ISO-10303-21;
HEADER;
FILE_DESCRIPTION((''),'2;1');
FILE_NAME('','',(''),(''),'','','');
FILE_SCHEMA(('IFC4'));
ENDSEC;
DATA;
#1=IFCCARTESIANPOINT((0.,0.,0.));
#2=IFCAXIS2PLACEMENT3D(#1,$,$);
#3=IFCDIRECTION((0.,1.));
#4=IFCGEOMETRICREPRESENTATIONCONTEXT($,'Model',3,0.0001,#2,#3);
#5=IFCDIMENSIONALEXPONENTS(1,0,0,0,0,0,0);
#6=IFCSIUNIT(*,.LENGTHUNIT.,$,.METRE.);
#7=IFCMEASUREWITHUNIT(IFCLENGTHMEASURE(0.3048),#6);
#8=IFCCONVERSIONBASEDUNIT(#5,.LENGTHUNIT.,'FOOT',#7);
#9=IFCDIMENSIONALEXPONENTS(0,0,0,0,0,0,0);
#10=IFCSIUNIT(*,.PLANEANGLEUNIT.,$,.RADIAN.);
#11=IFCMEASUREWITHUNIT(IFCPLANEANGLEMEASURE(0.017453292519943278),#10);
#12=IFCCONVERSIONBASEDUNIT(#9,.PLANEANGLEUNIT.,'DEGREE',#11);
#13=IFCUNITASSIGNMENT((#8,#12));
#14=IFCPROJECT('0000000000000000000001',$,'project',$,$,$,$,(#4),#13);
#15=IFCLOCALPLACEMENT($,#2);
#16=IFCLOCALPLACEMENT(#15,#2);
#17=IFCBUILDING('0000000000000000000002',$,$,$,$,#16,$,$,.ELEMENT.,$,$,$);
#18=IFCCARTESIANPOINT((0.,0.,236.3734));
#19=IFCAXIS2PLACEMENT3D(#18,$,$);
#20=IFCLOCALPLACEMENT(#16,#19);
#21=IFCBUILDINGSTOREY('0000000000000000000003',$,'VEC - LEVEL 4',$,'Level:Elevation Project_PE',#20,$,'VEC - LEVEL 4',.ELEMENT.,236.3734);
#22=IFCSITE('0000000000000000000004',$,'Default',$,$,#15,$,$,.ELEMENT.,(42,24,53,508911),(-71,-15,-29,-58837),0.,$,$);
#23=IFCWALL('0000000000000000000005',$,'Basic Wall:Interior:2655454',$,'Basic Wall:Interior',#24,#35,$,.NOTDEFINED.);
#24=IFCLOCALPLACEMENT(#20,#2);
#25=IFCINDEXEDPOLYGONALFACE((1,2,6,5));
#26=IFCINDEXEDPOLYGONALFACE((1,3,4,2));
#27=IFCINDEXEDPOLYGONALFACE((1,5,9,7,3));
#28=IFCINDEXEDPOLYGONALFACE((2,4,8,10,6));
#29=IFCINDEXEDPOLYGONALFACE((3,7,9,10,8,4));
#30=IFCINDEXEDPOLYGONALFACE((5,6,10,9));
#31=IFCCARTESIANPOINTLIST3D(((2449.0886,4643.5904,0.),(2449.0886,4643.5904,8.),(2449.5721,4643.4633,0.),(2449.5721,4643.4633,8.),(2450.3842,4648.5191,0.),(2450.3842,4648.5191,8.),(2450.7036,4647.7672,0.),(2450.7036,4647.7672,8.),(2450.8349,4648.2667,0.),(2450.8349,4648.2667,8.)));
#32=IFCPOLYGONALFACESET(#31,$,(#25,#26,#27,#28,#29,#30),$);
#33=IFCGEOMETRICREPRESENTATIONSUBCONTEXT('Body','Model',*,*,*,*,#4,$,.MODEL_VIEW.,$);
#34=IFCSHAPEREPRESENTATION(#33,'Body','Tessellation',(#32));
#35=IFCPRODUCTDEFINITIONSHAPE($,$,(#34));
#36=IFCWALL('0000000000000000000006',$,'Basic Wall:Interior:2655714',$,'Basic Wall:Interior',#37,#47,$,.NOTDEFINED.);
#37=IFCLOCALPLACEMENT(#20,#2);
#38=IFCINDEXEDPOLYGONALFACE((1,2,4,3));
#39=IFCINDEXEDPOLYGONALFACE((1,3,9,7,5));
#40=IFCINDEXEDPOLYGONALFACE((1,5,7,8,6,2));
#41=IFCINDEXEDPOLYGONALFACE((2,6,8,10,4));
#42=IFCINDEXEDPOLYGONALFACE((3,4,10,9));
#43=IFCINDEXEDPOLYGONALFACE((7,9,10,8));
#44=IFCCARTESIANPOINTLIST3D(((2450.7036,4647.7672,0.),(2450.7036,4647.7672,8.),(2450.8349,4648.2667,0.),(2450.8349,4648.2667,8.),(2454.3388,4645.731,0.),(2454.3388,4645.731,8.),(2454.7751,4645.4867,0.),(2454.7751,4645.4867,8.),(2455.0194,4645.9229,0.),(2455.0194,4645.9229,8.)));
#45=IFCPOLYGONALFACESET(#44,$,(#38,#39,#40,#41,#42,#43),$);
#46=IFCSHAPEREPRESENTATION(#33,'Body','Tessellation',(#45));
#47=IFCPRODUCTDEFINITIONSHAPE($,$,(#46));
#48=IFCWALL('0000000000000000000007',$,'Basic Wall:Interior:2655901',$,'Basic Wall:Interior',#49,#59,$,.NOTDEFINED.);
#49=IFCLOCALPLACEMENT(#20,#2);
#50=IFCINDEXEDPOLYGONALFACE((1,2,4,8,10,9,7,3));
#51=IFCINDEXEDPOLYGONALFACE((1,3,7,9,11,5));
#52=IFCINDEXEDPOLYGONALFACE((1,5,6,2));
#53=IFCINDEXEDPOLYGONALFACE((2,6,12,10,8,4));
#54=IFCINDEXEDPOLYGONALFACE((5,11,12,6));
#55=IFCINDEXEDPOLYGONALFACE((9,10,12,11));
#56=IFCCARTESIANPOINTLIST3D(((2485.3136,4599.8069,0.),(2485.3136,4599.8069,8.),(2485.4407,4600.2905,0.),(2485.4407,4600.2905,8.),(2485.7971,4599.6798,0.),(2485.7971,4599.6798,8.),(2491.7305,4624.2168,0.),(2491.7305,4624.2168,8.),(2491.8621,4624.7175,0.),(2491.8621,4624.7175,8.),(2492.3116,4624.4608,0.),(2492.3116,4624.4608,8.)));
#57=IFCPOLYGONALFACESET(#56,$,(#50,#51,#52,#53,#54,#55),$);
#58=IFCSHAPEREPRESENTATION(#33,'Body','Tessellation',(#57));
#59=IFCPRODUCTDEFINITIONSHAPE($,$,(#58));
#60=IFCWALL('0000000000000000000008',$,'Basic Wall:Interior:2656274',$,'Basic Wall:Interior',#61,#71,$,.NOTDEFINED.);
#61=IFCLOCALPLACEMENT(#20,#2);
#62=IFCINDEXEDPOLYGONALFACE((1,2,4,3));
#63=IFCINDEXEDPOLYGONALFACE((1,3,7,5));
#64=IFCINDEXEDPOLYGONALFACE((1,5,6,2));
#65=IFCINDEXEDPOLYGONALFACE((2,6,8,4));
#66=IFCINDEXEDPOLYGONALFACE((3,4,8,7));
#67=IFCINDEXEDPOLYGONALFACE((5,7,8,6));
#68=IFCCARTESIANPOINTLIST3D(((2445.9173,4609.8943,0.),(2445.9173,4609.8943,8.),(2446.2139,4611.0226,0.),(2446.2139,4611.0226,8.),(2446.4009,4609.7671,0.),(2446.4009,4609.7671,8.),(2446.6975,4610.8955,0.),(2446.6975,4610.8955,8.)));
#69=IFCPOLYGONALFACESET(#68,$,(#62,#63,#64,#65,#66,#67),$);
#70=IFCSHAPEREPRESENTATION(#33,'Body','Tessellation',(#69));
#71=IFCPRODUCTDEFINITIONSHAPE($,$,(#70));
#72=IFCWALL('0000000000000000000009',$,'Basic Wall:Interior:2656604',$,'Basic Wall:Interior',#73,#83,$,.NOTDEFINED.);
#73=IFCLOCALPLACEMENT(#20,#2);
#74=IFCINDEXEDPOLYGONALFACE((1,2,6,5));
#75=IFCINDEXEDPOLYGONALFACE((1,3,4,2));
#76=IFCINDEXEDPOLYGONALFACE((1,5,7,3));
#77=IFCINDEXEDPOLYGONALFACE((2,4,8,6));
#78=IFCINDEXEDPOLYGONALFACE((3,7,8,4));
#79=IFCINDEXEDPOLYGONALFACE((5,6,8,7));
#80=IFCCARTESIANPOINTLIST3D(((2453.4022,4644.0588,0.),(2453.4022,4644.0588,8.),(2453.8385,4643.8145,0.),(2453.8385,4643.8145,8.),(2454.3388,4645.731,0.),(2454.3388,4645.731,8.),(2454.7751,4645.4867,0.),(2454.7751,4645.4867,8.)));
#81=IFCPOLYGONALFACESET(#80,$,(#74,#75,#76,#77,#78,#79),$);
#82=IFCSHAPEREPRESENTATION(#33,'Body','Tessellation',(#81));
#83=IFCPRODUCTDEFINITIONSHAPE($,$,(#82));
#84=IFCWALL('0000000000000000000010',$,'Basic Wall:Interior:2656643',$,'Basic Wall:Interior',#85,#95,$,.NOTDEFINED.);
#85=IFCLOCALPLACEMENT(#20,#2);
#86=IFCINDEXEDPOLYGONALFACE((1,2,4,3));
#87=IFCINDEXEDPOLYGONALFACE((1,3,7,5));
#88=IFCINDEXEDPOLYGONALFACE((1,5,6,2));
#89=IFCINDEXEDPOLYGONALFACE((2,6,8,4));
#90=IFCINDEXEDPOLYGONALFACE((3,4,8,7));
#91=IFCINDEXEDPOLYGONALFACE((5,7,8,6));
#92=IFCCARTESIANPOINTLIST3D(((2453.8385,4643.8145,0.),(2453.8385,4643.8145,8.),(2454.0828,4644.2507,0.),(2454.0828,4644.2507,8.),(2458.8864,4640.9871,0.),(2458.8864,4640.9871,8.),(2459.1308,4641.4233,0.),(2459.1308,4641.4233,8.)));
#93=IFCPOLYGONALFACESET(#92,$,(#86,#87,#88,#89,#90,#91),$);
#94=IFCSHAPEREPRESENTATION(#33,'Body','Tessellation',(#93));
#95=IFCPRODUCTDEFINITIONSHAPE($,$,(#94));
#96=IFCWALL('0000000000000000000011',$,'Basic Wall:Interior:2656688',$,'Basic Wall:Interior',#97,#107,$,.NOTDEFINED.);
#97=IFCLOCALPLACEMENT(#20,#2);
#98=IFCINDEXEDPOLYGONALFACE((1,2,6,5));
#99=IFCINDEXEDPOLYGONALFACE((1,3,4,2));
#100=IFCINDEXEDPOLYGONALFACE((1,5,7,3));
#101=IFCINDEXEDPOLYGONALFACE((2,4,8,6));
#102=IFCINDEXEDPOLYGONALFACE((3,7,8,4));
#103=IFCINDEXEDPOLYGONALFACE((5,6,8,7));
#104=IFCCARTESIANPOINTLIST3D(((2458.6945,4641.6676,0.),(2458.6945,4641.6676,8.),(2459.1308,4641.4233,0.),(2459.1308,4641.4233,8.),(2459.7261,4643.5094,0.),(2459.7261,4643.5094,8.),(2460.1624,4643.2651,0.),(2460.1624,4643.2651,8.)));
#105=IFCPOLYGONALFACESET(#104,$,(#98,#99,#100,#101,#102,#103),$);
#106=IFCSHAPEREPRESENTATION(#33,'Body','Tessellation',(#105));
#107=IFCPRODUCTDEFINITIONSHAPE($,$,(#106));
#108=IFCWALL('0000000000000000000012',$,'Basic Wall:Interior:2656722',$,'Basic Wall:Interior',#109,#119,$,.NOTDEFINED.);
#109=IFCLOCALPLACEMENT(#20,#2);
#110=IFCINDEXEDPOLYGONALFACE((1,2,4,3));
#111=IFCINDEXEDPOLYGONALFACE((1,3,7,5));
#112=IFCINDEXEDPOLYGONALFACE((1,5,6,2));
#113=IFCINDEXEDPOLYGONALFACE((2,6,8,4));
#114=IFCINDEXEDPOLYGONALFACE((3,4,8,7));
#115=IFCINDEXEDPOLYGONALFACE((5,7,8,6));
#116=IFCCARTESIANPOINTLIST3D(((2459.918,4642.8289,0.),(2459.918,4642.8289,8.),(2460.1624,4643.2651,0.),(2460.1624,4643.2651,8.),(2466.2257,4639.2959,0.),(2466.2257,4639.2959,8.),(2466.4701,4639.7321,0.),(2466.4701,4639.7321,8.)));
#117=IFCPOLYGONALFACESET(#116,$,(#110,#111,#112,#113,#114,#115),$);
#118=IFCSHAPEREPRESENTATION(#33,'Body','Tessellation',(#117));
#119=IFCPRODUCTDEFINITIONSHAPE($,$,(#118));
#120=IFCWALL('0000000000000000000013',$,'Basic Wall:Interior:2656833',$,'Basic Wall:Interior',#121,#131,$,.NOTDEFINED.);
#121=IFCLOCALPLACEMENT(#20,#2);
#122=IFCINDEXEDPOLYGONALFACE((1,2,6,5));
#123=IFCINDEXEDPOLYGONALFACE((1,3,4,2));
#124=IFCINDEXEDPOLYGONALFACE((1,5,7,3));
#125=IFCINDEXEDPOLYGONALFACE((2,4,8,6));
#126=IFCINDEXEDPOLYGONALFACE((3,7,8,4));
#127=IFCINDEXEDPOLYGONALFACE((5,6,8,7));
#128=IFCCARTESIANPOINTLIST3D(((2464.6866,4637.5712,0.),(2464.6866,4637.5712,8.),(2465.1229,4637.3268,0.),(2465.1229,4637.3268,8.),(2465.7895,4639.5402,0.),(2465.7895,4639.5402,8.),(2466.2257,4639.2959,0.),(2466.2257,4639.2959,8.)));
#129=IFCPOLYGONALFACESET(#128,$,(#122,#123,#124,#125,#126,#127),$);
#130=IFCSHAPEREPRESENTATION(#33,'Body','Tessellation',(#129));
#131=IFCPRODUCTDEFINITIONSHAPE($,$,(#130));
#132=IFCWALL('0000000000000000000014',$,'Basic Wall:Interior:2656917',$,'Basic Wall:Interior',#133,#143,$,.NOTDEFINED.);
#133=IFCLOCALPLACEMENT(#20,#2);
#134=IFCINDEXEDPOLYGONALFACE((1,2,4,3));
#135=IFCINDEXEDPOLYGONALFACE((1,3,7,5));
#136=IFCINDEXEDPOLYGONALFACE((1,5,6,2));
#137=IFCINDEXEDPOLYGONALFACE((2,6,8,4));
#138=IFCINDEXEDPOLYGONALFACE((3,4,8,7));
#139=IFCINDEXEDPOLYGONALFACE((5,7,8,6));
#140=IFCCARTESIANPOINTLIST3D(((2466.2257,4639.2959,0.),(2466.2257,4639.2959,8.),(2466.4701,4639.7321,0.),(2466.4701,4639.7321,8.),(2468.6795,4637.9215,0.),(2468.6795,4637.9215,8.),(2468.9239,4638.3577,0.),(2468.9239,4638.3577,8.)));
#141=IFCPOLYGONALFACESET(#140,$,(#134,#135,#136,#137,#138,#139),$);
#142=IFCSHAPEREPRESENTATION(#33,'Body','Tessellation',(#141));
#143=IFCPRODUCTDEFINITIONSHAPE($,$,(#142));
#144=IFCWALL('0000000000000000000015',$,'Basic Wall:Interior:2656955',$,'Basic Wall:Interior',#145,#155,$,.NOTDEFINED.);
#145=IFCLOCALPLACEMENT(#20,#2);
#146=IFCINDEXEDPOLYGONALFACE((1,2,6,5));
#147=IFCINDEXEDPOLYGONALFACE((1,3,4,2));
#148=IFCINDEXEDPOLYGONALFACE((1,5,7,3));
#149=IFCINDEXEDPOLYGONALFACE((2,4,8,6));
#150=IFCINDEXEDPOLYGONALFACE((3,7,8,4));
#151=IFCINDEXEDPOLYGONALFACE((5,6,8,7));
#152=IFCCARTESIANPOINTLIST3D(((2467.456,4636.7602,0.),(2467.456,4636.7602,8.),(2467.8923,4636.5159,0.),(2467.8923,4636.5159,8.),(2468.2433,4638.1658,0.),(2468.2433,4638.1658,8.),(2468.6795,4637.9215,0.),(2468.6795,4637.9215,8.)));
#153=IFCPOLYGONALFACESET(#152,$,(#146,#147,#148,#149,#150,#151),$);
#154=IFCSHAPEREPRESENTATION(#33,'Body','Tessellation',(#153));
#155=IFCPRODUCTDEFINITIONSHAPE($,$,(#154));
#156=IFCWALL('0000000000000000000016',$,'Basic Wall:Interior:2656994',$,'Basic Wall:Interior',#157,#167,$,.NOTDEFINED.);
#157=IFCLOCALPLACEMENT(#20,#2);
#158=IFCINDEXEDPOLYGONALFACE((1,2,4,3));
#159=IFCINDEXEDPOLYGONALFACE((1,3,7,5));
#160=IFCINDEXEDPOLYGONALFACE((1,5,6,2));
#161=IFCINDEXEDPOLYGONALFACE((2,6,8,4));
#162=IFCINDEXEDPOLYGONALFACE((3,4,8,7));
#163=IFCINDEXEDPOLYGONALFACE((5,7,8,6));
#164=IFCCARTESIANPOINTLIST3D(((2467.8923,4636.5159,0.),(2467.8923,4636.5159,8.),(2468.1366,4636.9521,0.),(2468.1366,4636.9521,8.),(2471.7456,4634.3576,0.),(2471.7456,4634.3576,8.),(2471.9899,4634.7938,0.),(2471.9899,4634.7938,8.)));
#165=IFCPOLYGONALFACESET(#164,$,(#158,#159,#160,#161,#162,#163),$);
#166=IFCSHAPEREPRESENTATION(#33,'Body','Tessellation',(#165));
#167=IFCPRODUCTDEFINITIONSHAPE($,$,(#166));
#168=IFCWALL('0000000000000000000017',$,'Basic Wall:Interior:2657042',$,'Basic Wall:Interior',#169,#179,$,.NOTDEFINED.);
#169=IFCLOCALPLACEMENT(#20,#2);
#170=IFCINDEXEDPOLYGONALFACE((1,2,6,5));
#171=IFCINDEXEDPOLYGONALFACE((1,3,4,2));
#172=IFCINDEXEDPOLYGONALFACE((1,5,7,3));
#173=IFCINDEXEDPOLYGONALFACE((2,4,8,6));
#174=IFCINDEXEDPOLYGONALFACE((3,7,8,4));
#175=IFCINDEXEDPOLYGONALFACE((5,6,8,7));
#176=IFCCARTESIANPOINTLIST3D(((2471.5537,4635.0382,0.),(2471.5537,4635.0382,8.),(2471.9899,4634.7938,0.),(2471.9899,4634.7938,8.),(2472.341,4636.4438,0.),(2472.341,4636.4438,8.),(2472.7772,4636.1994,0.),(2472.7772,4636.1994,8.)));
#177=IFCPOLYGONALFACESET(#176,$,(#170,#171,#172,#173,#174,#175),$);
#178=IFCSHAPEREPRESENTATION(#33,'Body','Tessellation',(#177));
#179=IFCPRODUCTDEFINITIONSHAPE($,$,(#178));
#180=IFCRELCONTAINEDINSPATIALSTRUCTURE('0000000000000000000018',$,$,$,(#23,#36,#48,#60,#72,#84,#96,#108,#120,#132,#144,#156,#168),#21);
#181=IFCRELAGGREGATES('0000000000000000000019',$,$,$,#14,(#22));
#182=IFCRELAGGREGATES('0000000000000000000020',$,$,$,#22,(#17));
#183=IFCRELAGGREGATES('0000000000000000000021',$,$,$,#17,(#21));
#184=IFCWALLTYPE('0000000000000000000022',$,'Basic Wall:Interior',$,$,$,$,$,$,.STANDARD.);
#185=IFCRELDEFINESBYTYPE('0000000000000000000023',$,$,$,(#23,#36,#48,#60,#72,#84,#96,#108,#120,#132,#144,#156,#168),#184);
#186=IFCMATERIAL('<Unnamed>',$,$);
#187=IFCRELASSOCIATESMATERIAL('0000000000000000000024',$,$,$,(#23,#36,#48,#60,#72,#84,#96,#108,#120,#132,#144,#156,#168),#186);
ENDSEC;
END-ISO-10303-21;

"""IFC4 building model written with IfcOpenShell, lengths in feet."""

from ifc_helpers import new_model, entity, si_unit, converted_unit, direction, frame, origin, place, context, subcontext, project, spatial, indexed_curve, outline, extrude, material, type_object, element, save


model = new_model("IFC4")

# Units and contexts
model_context = context("Model", 3, precision=0.0001, world=origin(), true_north=direction((0.0, 1.0)))
body_context = subcontext(model_context, "Body", "Model", "MODEL_VIEW")
ifc_project = project(units=[converted_unit("LENGTHUNIT", "FOOT", entity("IfcLengthMeasure", 0.3048), si_unit("LENGTHUNIT", "METRE"), dimensions=[1, 0, 0, 0, 0, 0, 0]), converted_unit("PLANEANGLEUNIT", "DEGREE", entity("IfcPlaneAngleMeasure", 0.017453292519943278), si_unit("PLANEANGLEUNIT", "RADIAN"), dimensions=[0, 0, 0, 0, 0, 0, 0])], contexts=[model_context])

# Site, building, storey
site_placement = place(None, origin())
site = spatial("IfcSite", under=ifc_project, at=site_placement, Name="Default", CompositionType="ELEMENT", RefLatitude=(42, 24, 53, 508911), RefLongitude=(-71, -15, -29, -58837), RefElevation=0.0)
building_placement = place(site_placement, origin())
building = spatial("IfcBuilding", under=site, at=building_placement, CompositionType="ELEMENT")
storey_placement = place(building_placement, frame((0.0, 0.0, 236.3734)))
storey = spatial("IfcBuildingStorey", under=building, at=storey_placement, Name="VEC - LEVEL 4", ObjectType="Level:Elevation Project_PE", LongName="VEC - LEVEL 4", CompositionType="ELEMENT", Elevation=236.3734)

# Walls
ifc_material_1 = material(Name="<Unnamed>")
wall_type = type_object("IfcWallType", Name="Basic Wall:Interior", PredefinedType="STANDARD")
wall_1_placement = place(storey_placement, frame((2449.3304, 4643.5268, 0.0), z_axis=(0.0, 0.0, 1.0), x_axis=(0.254244, 0.96714, 0.0)))
element("IfcWall", 1, at=wall_1_placement, inside=storey, type_object=wall_type, material=ifc_material_1, Name="Basic Wall:Interior:2655454", ObjectType="Basic Wall:Interior", PredefinedType="NOTDEFINED", context=body_context, shape_type="SweptSolid", body=[
    extrude(outline(indexed_curve([(4.9666, -0.25), (5.0962, 0.25), (0.0, 0.25), (0.0, -0.25), (4.4501, -0.25), (4.9666, -0.25)], self_intersect=False)), origin(), (0.0, 0.0, 1.0), 8.0),
])
wall_2_placement = place(storey_placement, frame((2450.7127, 4648.0486, 0.0), z_axis=(0.0, 0.0, 1.0), x_axis=(0.872466, -0.488675, 0.0)))
element("IfcWall", 2, at=wall_2_placement, inside=storey, type_object=wall_type, material=ifc_material_1, Name="Basic Wall:Interior:2655714", ObjectType="Basic Wall:Interior", PredefinedType="NOTDEFINED", context=body_context, shape_type="SweptSolid", body=[
    extrude(outline(indexed_curve([(4.7962, -0.25), (4.7962, 0.25), (0.0, 0.25), (0.1295, -0.25), (4.2962, -0.25), (4.7962, -0.25)], self_intersect=False)), origin(), (0.0, 0.0, 1.0), 8.0),
])
wall_3_placement = place(storey_placement, frame((2492.1039, 4624.6539, 0.0), z_axis=(0.0, 0.0, 1.0), x_axis=(-0.254244, -0.96714, 0.0)))
element("IfcWall", 3, at=wall_3_placement, inside=storey, type_object=wall_type, material=ifc_material_1, Name="Basic Wall:Interior:2655901", ObjectType="Basic Wall:Interior", PredefinedType="NOTDEFINED", context=body_context, shape_type="SweptSolid", body=[
    extrude(outline(indexed_curve([(25.7569, -0.25), (25.7569, 0.25), (0.134, 0.25), (0.0, -0.25), (0.5176, -0.25), (25.2569, -0.25), (25.7569, -0.25)], self_intersect=False)), origin(), (0.0, 0.0, 1.0), 8.0),
])
wall_4_placement = place(storey_placement, frame((2446.4557, 4610.959, 0.0), z_axis=(0.0, 0.0, 1.0), x_axis=(-0.254244, -0.96714, 0.0)))
element("IfcWall", 4, at=wall_4_placement, inside=storey, type_object=wall_type, material=ifc_material_1, Name="Basic Wall:Interior:2656274", ObjectType="Basic Wall:Interior", PredefinedType="NOTDEFINED", context=body_context, shape_type="SweptSolid", body=[
    extrude(outline(indexed_curve([(1.1667, 0.25), (0.0, 0.25), (0.0, -0.25), (1.1667, -0.25), (1.1667, 0.25)], self_intersect=False)), origin(), (0.0, 0.0, 1.0), 8.0),
])
wall_5_placement = place(storey_placement, frame((2454.557, 4645.6089, 0.0), z_axis=(0.0, 0.0, 1.0), x_axis=(-0.488675, -0.872466, 0.0)))
element("IfcWall", 5, at=wall_5_placement, inside=storey, type_object=wall_type, material=ifc_material_1, Name="Basic Wall:Interior:2656604", ObjectType="Basic Wall:Interior", PredefinedType="NOTDEFINED", context=body_context, shape_type="SweptSolid", body=[
    extrude(outline(indexed_curve([(1.9167, 0.25), (0.0, 0.25), (0.0, -0.25), (1.9167, -0.25), (1.9167, 0.25)], self_intersect=False)), origin(), (0.0, 0.0, 1.0), 8.0),
])
wall_6_placement = place(storey_placement, frame((2453.9606, 4644.0326, 0.0), z_axis=(0.0, 0.0, 1.0), x_axis=(0.872466, -0.488675, 0.0)))
element("IfcWall", 6, at=wall_6_placement, inside=storey, type_object=wall_type, material=ifc_material_1, Name="Basic Wall:Interior:2656643", ObjectType="Basic Wall:Interior", PredefinedType="NOTDEFINED", context=body_context, shape_type="SweptSolid", body=[
    extrude(outline(indexed_curve([(5.7859, 0.25), (0.0, 0.25), (0.0, -0.25), (5.7859, -0.25), (5.7859, 0.25)], self_intersect=False)), origin(), (0.0, 0.0, 1.0), 8.0),
])
wall_7_placement = place(storey_placement, frame((2458.9126, 4641.5455, 0.0), z_axis=(0.0, 0.0, 1.0), x_axis=(0.488675, 0.872466, 0.0)))
element("IfcWall", 7, at=wall_7_placement, inside=storey, type_object=wall_type, material=ifc_material_1, Name="Basic Wall:Interior:2656688", ObjectType="Basic Wall:Interior", PredefinedType="NOTDEFINED", context=body_context, shape_type="SweptSolid", body=[
    extrude(outline(indexed_curve([(2.111, 0.25), (0.0, 0.25), (0.0, -0.25), (2.111, -0.25), (2.111, 0.25)], self_intersect=False)), origin(), (0.0, 0.0, 1.0), 8.0),
])
wall_8_placement = place(storey_placement, frame((2460.0402, 4643.047, 0.0), z_axis=(0.0, 0.0, 1.0), x_axis=(0.872466, -0.488675, 0.0)))
element("IfcWall", 8, at=wall_8_placement, inside=storey, type_object=wall_type, material=ifc_material_1, Name="Basic Wall:Interior:2656722", ObjectType="Basic Wall:Interior", PredefinedType="NOTDEFINED", context=body_context, shape_type="SweptSolid", body=[
    extrude(outline(indexed_curve([(7.2297, 0.25), (0.0, 0.25), (0.0, -0.25), (7.2297, -0.25), (7.2297, 0.25)], self_intersect=False)), origin(), (0.0, 0.0, 1.0), 8.0),
])
wall_9_placement = place(storey_placement, frame((2466.0076, 4639.418, 0.0), z_axis=(0.0, 0.0, 1.0), x_axis=(-0.488675, -0.872466, 0.0)))
element("IfcWall", 9, at=wall_9_placement, inside=storey, type_object=wall_type, material=ifc_material_1, Name="Basic Wall:Interior:2656833", ObjectType="Basic Wall:Interior", PredefinedType="NOTDEFINED", context=body_context, shape_type="SweptSolid", body=[
    extrude(outline(indexed_curve([(2.2569, 0.25), (0.0, 0.25), (0.0, -0.25), (2.2569, -0.25), (2.2569, 0.25)], self_intersect=False)), origin(), (0.0, 0.0, 1.0), 8.0),
])
wall_10_placement = place(storey_placement, frame((2466.3479, 4639.514, 0.0), z_axis=(0.0, 0.0, 1.0), x_axis=(0.872466, -0.488675, 0.0)))
element("IfcWall", 10, at=wall_10_placement, inside=storey, type_object=wall_type, material=ifc_material_1, Name="Basic Wall:Interior:2656917", ObjectType="Basic Wall:Interior", PredefinedType="NOTDEFINED", context=body_context, shape_type="SweptSolid", body=[
    extrude(outline(indexed_curve([(2.8125, 0.25), (0.0, 0.25), (0.0, -0.25), (2.8125, -0.25), (2.8125, 0.25)], self_intersect=False)), origin(), (0.0, 0.0, 1.0), 8.0),
])
wall_11_placement = place(storey_placement, frame((2468.4614, 4638.0436, 0.0), z_axis=(0.0, 0.0, 1.0), x_axis=(-0.488675, -0.872466, 0.0)))
element("IfcWall", 11, at=wall_11_placement, inside=storey, type_object=wall_type, material=ifc_material_1, Name="Basic Wall:Interior:2656955", ObjectType="Basic Wall:Interior", PredefinedType="NOTDEFINED", context=body_context, shape_type="SweptSolid", body=[
    extrude(outline(indexed_curve([(1.611, 0.25), (0.0, 0.25), (0.0, -0.25), (1.611, -0.25), (1.611, 0.25)], self_intersect=False)), origin(), (0.0, 0.0, 1.0), 8.0),
])
wall_12_placement = place(storey_placement, frame((2468.0144, 4636.734, 0.0), z_axis=(0.0, 0.0, 1.0), x_axis=(0.872466, -0.488675, 0.0)))
element("IfcWall", 12, at=wall_12_placement, inside=storey, type_object=wall_type, material=ifc_material_1, Name="Basic Wall:Interior:2656994", ObjectType="Basic Wall:Interior", PredefinedType="NOTDEFINED", context=body_context, shape_type="SweptSolid", body=[
    extrude(outline(indexed_curve([(4.4166, 0.25), (0.0, 0.25), (0.0, -0.25), (4.4166, -0.25), (4.4166, 0.25)], self_intersect=False)), origin(), (0.0, 0.0, 1.0), 8.0),
])
wall_13_placement = place(storey_placement, frame((2471.7718, 4634.916, 0.0), z_axis=(0.0, 0.0, 1.0), x_axis=(0.488675, 0.872466, 0.0)))
element("IfcWall", 13, at=wall_13_placement, inside=storey, type_object=wall_type, material=ifc_material_1, Name="Basic Wall:Interior:2657042", ObjectType="Basic Wall:Interior", PredefinedType="NOTDEFINED", context=body_context, shape_type="SweptSolid", body=[
    extrude(outline(indexed_curve([(1.611, 0.25), (0.0, 0.25), (0.0, -0.25), (1.611, -0.25), (1.611, 0.25)], self_intersect=False)), origin(), (0.0, 0.0, 1.0), 8.0),
])

save(model, "model.ifc")
